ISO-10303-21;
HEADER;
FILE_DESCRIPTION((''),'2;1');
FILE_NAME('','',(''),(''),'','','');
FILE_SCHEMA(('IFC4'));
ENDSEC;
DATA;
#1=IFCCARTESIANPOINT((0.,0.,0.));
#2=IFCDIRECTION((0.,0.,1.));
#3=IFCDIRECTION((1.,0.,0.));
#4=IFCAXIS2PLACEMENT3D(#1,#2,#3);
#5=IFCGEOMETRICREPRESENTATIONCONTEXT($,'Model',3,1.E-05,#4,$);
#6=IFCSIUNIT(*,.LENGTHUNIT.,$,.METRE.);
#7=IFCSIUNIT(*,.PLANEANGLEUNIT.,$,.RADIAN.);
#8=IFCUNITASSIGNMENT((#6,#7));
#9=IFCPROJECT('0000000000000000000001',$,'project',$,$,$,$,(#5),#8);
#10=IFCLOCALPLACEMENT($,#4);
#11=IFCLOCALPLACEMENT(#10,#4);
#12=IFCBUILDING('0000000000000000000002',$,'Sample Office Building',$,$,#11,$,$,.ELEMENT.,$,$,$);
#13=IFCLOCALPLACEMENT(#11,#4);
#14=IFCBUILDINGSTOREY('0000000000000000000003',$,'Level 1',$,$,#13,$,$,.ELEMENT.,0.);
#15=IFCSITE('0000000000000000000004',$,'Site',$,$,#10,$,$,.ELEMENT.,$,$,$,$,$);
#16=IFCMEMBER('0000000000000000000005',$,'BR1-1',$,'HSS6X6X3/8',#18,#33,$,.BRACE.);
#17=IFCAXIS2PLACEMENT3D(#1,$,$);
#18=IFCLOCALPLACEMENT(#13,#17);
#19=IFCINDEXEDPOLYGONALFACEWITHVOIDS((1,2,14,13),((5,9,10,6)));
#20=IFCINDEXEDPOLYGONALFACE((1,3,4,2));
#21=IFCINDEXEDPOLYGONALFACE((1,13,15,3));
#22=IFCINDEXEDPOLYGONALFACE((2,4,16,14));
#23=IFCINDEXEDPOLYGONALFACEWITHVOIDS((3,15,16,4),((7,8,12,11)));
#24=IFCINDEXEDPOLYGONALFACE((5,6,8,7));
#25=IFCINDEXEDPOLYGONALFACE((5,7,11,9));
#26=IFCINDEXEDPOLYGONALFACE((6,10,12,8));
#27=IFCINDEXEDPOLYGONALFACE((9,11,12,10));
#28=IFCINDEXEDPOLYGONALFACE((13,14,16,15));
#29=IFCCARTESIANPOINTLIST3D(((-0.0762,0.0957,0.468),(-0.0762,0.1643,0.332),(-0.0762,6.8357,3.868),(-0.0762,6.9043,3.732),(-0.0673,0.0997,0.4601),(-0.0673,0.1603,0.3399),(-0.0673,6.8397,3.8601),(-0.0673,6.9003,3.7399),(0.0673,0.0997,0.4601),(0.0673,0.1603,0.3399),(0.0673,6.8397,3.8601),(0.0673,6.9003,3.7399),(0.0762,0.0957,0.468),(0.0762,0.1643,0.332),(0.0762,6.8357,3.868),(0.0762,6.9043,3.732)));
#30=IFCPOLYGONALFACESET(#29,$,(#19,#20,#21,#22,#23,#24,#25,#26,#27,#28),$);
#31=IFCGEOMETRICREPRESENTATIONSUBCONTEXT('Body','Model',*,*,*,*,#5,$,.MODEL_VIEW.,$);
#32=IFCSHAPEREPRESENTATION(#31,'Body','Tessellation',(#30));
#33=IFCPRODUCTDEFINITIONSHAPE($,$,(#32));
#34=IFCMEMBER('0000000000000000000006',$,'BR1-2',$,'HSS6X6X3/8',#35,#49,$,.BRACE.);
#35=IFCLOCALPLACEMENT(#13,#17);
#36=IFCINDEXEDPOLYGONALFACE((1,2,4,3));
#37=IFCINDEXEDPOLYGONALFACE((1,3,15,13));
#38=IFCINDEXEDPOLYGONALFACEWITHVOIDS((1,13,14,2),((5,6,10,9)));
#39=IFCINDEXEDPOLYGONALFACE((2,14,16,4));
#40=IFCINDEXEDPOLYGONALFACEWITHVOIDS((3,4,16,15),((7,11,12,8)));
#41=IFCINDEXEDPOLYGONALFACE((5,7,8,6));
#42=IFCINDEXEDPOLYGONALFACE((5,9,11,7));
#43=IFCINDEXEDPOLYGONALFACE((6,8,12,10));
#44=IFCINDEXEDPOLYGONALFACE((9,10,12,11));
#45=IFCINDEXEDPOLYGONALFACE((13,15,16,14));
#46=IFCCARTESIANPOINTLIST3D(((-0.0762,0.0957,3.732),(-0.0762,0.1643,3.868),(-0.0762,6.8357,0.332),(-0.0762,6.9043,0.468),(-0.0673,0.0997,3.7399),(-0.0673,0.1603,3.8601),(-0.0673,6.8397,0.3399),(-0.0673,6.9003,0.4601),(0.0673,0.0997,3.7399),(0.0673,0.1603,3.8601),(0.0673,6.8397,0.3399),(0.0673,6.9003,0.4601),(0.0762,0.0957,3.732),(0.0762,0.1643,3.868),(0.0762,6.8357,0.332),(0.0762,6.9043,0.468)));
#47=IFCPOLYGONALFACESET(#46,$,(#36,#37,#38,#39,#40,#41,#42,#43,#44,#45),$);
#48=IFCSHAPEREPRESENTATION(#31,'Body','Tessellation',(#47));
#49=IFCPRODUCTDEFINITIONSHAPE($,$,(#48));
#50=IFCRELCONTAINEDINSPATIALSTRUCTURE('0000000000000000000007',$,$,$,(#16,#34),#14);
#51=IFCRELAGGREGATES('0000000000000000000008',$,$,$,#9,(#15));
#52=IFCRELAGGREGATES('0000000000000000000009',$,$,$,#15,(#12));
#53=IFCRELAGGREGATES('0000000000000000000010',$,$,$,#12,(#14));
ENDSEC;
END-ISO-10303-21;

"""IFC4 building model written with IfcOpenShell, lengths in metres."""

from ifc_helpers import new_model, si_unit, frame, origin_with_axes, place, context, subcontext, project, spatial, hollow_rectangle, extrude, element, save


model = new_model("IFC4")

# Units and contexts
model_context = context("Model", 3, precision=1e-05, world=origin_with_axes())
body_context = subcontext(model_context, "Body", "Model", "MODEL_VIEW")
ifc_project = project(units=[si_unit("LENGTHUNIT", "METRE"), si_unit("PLANEANGLEUNIT", "RADIAN")], contexts=[model_context])

# Site, building, storey
site_placement = place(None, origin_with_axes())
site = spatial("IfcSite", under=ifc_project, at=site_placement, Name="Site", CompositionType="ELEMENT")
building_placement = place(site_placement, origin_with_axes())
building = spatial("IfcBuilding", under=site, at=building_placement, Name="Sample Office Building", CompositionType="ELEMENT")
storey_placement = place(building_placement, origin_with_axes())
storey = spatial("IfcBuildingStorey", under=building, at=storey_placement, Name="Level 1", CompositionType="ELEMENT", Elevation=0.0)

# Members
for number, where, z_axis, x_axis, name in (
    (1, (0.0, 0.13, 0.4), (0.0, 0.892832, 0.45039), (-1.0, 0.0, 0.0), "BR1-1"),
    (2, (0.0, 6.87, 0.4), (0.0, -0.892832, 0.45039), (1.0, 0.0, 0.0), "BR1-2"),
):
    element("IfcMember", number, at=place(None, frame(where, z_axis=z_axis, x_axis=x_axis)), inside=storey, Name=name, ObjectType="HSS6X6X3/8", PredefinedType="BRACE", context=body_context, shape_type="SweptSolid", body=[
        extrude(hollow_rectangle(XDim=0.1524, YDim=0.1524, WallThickness=0.0089), None, (0.0, 0.0, 1.0), 7.549),
    ])

save(model, "model.ifc")
